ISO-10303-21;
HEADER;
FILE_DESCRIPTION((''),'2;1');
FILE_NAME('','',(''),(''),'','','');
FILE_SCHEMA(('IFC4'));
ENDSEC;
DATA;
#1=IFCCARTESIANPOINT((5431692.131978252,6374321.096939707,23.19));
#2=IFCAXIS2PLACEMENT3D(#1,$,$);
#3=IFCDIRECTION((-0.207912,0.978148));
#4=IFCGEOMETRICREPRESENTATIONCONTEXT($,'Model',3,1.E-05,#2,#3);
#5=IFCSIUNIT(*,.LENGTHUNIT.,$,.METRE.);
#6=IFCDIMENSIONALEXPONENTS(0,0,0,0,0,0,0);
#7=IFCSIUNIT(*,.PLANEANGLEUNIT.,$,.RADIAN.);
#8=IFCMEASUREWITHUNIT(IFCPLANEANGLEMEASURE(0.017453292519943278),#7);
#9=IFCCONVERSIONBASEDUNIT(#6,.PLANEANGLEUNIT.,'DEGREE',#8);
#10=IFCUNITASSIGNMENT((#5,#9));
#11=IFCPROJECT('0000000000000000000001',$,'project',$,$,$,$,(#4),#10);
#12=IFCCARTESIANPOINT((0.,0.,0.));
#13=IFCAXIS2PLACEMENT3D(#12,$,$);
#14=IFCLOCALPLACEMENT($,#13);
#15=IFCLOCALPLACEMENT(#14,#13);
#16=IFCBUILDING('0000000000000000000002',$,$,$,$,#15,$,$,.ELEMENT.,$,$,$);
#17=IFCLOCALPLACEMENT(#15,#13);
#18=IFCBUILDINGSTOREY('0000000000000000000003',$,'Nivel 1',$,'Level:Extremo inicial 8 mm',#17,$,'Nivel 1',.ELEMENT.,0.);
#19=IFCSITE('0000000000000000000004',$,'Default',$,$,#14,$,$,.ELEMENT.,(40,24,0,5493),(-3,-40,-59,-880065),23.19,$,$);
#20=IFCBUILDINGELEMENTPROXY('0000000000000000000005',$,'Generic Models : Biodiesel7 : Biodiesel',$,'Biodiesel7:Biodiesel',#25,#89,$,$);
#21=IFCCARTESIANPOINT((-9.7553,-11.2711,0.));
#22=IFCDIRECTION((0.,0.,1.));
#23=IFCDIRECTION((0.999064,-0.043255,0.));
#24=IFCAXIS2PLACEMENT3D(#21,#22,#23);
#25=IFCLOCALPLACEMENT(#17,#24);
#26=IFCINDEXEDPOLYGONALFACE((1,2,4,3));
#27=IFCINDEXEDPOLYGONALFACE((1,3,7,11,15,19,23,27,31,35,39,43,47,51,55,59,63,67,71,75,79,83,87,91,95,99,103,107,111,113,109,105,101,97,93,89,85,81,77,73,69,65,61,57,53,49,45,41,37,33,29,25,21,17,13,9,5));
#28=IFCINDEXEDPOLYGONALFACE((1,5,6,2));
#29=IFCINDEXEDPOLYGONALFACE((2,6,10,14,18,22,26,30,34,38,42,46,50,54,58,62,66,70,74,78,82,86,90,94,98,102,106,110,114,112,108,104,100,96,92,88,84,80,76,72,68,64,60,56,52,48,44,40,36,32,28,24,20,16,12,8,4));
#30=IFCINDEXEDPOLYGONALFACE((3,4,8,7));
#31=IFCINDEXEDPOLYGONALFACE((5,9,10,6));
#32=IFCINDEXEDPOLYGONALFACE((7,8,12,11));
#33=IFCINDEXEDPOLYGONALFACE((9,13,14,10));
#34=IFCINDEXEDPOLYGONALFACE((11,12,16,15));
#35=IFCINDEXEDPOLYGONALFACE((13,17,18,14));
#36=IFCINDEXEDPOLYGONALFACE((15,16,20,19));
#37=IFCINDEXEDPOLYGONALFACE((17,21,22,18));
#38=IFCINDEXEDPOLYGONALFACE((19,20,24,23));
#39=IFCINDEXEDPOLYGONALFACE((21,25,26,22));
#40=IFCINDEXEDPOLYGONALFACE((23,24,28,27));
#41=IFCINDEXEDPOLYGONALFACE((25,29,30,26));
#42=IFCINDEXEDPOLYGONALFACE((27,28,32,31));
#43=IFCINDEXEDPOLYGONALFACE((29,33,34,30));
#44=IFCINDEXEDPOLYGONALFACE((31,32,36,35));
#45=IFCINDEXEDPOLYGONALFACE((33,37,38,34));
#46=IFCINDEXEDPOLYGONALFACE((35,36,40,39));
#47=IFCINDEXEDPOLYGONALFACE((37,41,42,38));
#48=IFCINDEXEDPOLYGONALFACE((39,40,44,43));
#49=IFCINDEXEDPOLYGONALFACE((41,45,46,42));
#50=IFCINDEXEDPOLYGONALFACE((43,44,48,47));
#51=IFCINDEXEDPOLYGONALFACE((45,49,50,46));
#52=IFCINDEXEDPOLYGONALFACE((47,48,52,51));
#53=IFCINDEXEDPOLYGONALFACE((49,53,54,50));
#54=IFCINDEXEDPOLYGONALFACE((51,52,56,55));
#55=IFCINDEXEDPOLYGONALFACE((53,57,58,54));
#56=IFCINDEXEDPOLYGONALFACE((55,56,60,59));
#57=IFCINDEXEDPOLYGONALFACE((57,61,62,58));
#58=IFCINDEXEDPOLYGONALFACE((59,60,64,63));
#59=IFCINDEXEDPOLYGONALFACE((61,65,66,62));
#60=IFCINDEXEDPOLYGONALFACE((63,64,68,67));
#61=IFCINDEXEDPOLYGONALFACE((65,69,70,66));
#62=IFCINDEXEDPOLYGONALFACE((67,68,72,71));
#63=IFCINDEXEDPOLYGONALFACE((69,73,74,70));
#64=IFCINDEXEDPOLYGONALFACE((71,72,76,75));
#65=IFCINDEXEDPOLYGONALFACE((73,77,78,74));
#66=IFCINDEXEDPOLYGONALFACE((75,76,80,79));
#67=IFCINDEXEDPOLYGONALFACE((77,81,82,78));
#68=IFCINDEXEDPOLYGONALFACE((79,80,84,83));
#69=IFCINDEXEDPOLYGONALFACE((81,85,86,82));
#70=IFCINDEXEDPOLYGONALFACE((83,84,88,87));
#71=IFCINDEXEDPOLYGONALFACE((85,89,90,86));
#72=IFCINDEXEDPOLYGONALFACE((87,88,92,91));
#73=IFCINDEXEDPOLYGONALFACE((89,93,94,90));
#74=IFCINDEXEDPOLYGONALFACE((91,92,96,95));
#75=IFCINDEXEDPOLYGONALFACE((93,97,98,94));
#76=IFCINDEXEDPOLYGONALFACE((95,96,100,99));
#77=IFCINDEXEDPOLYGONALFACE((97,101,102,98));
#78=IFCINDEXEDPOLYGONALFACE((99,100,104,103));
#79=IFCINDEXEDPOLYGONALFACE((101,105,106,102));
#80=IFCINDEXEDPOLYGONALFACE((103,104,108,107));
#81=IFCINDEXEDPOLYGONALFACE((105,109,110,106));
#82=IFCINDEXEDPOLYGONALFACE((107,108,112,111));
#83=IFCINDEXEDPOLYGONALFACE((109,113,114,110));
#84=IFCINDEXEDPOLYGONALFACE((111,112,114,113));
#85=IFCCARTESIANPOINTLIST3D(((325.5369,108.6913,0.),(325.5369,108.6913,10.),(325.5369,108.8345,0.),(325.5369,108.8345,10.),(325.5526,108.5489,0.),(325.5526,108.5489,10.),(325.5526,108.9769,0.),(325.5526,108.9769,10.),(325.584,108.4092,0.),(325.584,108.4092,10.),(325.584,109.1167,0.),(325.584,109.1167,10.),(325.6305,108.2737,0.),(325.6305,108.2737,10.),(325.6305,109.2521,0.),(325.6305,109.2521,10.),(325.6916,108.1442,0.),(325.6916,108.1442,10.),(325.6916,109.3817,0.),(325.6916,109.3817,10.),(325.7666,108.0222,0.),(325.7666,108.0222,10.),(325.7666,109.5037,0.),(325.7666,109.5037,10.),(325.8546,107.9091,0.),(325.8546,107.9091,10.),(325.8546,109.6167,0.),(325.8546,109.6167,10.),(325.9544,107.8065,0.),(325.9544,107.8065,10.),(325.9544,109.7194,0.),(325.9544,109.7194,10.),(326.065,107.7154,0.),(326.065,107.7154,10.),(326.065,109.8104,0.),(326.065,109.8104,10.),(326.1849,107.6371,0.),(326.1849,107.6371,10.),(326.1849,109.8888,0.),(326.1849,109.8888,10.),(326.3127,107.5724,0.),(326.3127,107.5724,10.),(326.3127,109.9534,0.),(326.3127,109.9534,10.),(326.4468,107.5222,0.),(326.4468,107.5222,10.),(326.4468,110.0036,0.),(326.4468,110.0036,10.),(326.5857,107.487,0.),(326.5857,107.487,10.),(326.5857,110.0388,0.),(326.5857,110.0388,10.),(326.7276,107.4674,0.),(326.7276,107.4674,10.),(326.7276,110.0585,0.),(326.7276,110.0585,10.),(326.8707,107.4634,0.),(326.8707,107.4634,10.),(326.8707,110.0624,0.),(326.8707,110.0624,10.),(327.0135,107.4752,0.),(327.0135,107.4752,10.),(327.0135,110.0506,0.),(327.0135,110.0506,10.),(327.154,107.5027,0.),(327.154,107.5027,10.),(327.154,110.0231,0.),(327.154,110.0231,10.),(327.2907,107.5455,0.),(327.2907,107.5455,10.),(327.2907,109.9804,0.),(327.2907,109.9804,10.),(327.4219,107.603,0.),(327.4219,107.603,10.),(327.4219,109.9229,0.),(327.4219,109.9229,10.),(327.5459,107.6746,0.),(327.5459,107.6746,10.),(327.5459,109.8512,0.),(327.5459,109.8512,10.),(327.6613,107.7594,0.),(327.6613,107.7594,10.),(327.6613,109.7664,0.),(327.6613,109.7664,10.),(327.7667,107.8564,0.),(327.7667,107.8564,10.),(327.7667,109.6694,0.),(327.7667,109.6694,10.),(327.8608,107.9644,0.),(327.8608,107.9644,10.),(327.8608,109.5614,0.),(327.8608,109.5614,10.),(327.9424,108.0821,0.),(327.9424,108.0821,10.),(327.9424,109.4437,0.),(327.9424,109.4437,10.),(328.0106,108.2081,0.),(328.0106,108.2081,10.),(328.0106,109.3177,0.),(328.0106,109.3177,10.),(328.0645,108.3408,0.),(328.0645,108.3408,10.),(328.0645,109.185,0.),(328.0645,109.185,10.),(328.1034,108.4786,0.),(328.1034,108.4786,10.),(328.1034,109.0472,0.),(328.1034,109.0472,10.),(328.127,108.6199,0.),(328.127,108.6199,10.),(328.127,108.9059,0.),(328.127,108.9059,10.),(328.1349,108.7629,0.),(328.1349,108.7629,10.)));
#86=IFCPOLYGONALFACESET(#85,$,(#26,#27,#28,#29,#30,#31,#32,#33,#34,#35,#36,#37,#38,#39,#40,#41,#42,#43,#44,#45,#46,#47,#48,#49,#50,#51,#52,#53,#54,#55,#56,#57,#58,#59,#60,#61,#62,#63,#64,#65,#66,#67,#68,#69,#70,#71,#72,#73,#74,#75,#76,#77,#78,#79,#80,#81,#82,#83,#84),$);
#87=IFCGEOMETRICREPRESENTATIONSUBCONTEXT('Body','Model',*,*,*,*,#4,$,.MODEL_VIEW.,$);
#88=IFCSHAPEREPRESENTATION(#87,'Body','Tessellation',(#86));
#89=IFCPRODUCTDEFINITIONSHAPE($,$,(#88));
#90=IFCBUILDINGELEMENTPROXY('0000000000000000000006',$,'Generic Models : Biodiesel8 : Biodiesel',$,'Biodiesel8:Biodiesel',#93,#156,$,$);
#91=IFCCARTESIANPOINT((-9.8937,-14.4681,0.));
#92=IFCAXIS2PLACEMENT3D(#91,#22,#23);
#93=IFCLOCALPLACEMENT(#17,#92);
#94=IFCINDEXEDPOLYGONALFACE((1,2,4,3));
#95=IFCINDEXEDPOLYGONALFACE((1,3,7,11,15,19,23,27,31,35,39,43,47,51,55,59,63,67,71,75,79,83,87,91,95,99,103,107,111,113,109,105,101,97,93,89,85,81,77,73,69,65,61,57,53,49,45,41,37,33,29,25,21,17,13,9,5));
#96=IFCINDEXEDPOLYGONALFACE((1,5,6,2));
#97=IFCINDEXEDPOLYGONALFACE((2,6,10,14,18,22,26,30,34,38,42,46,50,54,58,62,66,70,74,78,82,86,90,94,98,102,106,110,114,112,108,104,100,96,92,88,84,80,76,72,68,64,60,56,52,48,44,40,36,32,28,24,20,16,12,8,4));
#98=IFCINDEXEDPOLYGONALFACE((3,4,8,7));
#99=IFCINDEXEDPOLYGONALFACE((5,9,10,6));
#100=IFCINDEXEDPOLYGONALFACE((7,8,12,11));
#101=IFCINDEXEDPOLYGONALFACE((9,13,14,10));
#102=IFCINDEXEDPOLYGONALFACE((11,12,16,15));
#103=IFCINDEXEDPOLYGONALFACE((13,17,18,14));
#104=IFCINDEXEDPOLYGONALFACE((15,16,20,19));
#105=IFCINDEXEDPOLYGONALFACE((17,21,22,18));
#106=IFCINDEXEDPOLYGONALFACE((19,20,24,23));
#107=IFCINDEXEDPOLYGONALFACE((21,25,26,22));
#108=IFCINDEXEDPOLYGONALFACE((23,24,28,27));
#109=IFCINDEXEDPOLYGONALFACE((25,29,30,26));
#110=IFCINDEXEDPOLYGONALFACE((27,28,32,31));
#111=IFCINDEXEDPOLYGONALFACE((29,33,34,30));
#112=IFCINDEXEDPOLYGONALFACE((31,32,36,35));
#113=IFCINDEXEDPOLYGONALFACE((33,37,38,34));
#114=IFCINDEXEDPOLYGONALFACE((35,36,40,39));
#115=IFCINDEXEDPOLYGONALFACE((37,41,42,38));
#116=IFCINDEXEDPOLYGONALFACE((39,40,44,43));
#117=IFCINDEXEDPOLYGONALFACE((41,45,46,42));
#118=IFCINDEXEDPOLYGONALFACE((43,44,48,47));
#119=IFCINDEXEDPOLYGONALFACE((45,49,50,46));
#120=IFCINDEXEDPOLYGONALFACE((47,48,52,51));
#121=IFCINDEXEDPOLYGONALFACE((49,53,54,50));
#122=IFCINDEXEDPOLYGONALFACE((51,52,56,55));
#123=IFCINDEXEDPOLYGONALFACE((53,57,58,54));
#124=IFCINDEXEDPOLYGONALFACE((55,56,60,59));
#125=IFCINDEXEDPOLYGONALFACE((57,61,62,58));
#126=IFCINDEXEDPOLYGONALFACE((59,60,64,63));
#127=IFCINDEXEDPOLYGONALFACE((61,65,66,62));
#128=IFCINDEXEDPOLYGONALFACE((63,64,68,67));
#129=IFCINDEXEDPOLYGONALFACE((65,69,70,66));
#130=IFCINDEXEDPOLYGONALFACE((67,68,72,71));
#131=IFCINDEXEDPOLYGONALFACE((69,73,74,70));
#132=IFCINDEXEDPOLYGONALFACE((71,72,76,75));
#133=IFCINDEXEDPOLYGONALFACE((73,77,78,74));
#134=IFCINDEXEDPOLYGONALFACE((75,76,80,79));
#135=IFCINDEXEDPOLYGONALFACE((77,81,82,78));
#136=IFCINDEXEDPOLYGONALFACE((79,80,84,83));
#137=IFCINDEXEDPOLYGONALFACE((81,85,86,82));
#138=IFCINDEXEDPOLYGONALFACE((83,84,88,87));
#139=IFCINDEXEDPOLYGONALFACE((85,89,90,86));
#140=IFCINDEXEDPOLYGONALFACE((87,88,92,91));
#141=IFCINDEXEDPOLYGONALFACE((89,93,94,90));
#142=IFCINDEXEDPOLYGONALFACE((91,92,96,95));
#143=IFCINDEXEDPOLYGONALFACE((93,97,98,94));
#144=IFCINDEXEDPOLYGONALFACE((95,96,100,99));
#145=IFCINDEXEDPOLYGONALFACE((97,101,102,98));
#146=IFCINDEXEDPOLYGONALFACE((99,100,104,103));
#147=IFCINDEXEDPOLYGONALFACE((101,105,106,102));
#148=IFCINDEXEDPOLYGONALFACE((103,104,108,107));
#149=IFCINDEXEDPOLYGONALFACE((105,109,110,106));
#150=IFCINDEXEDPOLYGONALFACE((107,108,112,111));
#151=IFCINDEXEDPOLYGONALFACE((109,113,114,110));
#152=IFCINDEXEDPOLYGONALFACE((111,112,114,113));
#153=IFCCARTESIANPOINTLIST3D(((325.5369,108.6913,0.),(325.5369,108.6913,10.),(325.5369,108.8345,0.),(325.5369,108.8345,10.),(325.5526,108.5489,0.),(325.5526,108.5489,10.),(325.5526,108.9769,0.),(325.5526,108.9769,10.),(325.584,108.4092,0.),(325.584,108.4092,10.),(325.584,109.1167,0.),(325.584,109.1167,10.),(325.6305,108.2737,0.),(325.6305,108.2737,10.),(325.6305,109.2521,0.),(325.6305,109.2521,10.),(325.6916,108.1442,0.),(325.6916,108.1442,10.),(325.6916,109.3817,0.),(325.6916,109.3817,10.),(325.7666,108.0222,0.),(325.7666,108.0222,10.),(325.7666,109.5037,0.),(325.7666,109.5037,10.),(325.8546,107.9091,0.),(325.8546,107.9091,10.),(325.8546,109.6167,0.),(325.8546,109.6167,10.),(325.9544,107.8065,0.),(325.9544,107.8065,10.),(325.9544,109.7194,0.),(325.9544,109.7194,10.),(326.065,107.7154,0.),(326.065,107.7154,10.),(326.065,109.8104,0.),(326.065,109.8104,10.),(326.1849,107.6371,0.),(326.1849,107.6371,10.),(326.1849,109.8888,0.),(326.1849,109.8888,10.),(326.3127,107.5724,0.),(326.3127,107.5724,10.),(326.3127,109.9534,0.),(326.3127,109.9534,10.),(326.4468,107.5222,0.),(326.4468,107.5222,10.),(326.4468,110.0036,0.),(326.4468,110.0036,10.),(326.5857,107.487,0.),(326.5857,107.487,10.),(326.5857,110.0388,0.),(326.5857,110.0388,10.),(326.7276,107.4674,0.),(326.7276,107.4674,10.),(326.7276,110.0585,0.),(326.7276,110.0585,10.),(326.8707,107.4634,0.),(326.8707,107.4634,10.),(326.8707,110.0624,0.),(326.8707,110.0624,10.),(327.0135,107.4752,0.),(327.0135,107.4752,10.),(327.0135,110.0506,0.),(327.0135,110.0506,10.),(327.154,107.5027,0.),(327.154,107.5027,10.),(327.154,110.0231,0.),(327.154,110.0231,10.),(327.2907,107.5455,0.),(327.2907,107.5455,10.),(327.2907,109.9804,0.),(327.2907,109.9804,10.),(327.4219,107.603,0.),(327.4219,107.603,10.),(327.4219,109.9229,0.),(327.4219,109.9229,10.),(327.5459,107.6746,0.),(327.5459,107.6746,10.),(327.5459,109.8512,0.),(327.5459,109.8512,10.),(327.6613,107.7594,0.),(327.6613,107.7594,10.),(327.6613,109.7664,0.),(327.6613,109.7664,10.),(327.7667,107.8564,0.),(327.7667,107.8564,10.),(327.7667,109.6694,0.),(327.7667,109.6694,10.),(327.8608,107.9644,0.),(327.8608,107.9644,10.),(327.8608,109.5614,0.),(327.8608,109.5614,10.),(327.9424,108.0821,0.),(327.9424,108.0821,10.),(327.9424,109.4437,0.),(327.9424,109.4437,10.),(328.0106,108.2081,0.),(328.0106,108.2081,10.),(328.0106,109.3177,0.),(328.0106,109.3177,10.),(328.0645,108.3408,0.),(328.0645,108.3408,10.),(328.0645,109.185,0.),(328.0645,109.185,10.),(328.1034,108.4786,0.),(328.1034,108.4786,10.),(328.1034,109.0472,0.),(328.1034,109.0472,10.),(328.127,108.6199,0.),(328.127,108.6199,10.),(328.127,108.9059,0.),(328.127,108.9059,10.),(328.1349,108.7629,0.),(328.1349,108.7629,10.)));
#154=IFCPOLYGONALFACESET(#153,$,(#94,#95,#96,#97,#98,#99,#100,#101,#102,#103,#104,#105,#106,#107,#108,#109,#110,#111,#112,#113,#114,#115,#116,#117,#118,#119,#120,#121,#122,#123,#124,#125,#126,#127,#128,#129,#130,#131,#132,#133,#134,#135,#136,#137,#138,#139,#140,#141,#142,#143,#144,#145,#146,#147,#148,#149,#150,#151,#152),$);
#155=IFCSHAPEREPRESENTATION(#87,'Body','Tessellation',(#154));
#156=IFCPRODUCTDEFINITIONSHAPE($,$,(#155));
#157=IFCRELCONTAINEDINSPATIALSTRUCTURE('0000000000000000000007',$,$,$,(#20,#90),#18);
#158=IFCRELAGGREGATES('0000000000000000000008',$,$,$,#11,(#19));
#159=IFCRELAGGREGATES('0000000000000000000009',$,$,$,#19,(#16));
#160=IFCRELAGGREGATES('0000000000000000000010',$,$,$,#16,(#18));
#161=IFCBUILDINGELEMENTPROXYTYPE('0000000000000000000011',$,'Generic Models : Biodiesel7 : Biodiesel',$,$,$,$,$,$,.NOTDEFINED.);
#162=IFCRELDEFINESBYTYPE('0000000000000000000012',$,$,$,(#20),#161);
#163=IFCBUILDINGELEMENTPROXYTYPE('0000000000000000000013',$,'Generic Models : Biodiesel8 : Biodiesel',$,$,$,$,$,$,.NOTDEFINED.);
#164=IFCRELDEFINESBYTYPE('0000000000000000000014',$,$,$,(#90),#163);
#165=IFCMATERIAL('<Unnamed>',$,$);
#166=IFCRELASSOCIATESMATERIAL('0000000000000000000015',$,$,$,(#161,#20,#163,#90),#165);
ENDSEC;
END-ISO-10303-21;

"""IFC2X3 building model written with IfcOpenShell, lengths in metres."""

from ifc_helpers import new_model, entity, si_unit, converted_unit, direction, frame, origin, origin_2d_with_axis, place, context, subcontext, project, spatial, circle, extrude, source, transform, mapped, material, type_object, type_shapes, element, save


model = new_model("IFC2X3")

# Units and contexts
model_context = context("Model", 3, precision=1e-05, world=frame((5431692.131978252, 6374321.096939707, 23.19)), true_north=direction((-0.207912, 0.978148)))
body_context = subcontext(model_context, "Body", "Model", "MODEL_VIEW")
ifc_project = project(units=[si_unit("LENGTHUNIT", "METRE"), converted_unit("PLANEANGLEUNIT", "DEGREE", entity("IfcPlaneAngleMeasure", 0.017453292519943278), si_unit("PLANEANGLEUNIT", "RADIAN"), dimensions=[0, 0, 0, 0, 0, 0, 0])], contexts=[model_context])

# Site, building, storey
site_placement = place(None, origin())
site = spatial("IfcSite", under=ifc_project, at=site_placement, Name="Default", CompositionType="ELEMENT", RefLatitude=(40, 24, 0, 5493), RefLongitude=(-3, -40, -59, -880065), RefElevation=23.19)
building_placement = place(site_placement, origin())
building = spatial("IfcBuilding", under=site, at=building_placement, CompositionType="ELEMENT")
storey_placement = place(building_placement, origin())
storey = spatial("IfcBuildingStorey", under=building, at=storey_placement, Name="Nivel 1", ObjectType="Level:Extremo inicial 8 mm", LongName="Nivel 1", CompositionType="ELEMENT", Elevation=0.0)

# Building element proxies
ifc_material_1 = material(Name="<Unnamed>")
building_element_proxy_type_1 = type_object("IfcBuildingElementProxyType", Name="Generic Models : Biodiesel7 : Biodiesel", PredefinedType="NOTDEFINED", material=ifc_material_1)
shared_shape_1 = source(origin(), body_context, "Body", "SweptSolid", [
    extrude(circle(Radius=1.3, at=origin_2d_with_axis()), frame((326.8349, 108.7629, 0.0)), (0.0, 0.0, 1.0), 10.0),
])
type_shapes(building_element_proxy_type_1, [shared_shape_1])
proxy_1_placement = place(storey_placement, frame((-9.7553, -11.2711, 0.0), z_axis=(0.0, 0.0, 1.0), x_axis=(0.999064, -0.043255, 0.0)))
element("IfcBuildingElementProxy", 1, at=proxy_1_placement, inside=storey, type_object=building_element_proxy_type_1, material=ifc_material_1, Name="Generic Models : Biodiesel7 : Biodiesel", ObjectType="Biodiesel7:Biodiesel", context=body_context, shape_type="MappedRepresentation", body=[
    mapped(shared_shape_1, transform((0.0, 0.0, 0.0), scale=1.0)),
])
building_element_proxy_type_2 = type_object("IfcBuildingElementProxyType", Name="Generic Models : Biodiesel8 : Biodiesel", PredefinedType="NOTDEFINED", material=ifc_material_1)
shared_shape_2 = source(origin(), body_context, "Body", "SweptSolid", [
    extrude(circle(Radius=1.3, at=origin_2d_with_axis()), frame((326.8349, 108.7629, 0.0)), (0.0, 0.0, 1.0), 10.0),
])
type_shapes(building_element_proxy_type_2, [shared_shape_2])
proxy_2_placement = place(storey_placement, frame((-9.8937, -14.4681, 0.0), z_axis=(0.0, 0.0, 1.0), x_axis=(0.999064, -0.043255, 0.0)))
element("IfcBuildingElementProxy", 2, at=proxy_2_placement, inside=storey, type_object=building_element_proxy_type_2, material=ifc_material_1, Name="Generic Models : Biodiesel8 : Biodiesel", ObjectType="Biodiesel8:Biodiesel", context=body_context, shape_type="MappedRepresentation", body=[
    mapped(shared_shape_2, transform((0.0, 0.0, 0.0), scale=1.0)),
])

save(model, "model.ifc")
